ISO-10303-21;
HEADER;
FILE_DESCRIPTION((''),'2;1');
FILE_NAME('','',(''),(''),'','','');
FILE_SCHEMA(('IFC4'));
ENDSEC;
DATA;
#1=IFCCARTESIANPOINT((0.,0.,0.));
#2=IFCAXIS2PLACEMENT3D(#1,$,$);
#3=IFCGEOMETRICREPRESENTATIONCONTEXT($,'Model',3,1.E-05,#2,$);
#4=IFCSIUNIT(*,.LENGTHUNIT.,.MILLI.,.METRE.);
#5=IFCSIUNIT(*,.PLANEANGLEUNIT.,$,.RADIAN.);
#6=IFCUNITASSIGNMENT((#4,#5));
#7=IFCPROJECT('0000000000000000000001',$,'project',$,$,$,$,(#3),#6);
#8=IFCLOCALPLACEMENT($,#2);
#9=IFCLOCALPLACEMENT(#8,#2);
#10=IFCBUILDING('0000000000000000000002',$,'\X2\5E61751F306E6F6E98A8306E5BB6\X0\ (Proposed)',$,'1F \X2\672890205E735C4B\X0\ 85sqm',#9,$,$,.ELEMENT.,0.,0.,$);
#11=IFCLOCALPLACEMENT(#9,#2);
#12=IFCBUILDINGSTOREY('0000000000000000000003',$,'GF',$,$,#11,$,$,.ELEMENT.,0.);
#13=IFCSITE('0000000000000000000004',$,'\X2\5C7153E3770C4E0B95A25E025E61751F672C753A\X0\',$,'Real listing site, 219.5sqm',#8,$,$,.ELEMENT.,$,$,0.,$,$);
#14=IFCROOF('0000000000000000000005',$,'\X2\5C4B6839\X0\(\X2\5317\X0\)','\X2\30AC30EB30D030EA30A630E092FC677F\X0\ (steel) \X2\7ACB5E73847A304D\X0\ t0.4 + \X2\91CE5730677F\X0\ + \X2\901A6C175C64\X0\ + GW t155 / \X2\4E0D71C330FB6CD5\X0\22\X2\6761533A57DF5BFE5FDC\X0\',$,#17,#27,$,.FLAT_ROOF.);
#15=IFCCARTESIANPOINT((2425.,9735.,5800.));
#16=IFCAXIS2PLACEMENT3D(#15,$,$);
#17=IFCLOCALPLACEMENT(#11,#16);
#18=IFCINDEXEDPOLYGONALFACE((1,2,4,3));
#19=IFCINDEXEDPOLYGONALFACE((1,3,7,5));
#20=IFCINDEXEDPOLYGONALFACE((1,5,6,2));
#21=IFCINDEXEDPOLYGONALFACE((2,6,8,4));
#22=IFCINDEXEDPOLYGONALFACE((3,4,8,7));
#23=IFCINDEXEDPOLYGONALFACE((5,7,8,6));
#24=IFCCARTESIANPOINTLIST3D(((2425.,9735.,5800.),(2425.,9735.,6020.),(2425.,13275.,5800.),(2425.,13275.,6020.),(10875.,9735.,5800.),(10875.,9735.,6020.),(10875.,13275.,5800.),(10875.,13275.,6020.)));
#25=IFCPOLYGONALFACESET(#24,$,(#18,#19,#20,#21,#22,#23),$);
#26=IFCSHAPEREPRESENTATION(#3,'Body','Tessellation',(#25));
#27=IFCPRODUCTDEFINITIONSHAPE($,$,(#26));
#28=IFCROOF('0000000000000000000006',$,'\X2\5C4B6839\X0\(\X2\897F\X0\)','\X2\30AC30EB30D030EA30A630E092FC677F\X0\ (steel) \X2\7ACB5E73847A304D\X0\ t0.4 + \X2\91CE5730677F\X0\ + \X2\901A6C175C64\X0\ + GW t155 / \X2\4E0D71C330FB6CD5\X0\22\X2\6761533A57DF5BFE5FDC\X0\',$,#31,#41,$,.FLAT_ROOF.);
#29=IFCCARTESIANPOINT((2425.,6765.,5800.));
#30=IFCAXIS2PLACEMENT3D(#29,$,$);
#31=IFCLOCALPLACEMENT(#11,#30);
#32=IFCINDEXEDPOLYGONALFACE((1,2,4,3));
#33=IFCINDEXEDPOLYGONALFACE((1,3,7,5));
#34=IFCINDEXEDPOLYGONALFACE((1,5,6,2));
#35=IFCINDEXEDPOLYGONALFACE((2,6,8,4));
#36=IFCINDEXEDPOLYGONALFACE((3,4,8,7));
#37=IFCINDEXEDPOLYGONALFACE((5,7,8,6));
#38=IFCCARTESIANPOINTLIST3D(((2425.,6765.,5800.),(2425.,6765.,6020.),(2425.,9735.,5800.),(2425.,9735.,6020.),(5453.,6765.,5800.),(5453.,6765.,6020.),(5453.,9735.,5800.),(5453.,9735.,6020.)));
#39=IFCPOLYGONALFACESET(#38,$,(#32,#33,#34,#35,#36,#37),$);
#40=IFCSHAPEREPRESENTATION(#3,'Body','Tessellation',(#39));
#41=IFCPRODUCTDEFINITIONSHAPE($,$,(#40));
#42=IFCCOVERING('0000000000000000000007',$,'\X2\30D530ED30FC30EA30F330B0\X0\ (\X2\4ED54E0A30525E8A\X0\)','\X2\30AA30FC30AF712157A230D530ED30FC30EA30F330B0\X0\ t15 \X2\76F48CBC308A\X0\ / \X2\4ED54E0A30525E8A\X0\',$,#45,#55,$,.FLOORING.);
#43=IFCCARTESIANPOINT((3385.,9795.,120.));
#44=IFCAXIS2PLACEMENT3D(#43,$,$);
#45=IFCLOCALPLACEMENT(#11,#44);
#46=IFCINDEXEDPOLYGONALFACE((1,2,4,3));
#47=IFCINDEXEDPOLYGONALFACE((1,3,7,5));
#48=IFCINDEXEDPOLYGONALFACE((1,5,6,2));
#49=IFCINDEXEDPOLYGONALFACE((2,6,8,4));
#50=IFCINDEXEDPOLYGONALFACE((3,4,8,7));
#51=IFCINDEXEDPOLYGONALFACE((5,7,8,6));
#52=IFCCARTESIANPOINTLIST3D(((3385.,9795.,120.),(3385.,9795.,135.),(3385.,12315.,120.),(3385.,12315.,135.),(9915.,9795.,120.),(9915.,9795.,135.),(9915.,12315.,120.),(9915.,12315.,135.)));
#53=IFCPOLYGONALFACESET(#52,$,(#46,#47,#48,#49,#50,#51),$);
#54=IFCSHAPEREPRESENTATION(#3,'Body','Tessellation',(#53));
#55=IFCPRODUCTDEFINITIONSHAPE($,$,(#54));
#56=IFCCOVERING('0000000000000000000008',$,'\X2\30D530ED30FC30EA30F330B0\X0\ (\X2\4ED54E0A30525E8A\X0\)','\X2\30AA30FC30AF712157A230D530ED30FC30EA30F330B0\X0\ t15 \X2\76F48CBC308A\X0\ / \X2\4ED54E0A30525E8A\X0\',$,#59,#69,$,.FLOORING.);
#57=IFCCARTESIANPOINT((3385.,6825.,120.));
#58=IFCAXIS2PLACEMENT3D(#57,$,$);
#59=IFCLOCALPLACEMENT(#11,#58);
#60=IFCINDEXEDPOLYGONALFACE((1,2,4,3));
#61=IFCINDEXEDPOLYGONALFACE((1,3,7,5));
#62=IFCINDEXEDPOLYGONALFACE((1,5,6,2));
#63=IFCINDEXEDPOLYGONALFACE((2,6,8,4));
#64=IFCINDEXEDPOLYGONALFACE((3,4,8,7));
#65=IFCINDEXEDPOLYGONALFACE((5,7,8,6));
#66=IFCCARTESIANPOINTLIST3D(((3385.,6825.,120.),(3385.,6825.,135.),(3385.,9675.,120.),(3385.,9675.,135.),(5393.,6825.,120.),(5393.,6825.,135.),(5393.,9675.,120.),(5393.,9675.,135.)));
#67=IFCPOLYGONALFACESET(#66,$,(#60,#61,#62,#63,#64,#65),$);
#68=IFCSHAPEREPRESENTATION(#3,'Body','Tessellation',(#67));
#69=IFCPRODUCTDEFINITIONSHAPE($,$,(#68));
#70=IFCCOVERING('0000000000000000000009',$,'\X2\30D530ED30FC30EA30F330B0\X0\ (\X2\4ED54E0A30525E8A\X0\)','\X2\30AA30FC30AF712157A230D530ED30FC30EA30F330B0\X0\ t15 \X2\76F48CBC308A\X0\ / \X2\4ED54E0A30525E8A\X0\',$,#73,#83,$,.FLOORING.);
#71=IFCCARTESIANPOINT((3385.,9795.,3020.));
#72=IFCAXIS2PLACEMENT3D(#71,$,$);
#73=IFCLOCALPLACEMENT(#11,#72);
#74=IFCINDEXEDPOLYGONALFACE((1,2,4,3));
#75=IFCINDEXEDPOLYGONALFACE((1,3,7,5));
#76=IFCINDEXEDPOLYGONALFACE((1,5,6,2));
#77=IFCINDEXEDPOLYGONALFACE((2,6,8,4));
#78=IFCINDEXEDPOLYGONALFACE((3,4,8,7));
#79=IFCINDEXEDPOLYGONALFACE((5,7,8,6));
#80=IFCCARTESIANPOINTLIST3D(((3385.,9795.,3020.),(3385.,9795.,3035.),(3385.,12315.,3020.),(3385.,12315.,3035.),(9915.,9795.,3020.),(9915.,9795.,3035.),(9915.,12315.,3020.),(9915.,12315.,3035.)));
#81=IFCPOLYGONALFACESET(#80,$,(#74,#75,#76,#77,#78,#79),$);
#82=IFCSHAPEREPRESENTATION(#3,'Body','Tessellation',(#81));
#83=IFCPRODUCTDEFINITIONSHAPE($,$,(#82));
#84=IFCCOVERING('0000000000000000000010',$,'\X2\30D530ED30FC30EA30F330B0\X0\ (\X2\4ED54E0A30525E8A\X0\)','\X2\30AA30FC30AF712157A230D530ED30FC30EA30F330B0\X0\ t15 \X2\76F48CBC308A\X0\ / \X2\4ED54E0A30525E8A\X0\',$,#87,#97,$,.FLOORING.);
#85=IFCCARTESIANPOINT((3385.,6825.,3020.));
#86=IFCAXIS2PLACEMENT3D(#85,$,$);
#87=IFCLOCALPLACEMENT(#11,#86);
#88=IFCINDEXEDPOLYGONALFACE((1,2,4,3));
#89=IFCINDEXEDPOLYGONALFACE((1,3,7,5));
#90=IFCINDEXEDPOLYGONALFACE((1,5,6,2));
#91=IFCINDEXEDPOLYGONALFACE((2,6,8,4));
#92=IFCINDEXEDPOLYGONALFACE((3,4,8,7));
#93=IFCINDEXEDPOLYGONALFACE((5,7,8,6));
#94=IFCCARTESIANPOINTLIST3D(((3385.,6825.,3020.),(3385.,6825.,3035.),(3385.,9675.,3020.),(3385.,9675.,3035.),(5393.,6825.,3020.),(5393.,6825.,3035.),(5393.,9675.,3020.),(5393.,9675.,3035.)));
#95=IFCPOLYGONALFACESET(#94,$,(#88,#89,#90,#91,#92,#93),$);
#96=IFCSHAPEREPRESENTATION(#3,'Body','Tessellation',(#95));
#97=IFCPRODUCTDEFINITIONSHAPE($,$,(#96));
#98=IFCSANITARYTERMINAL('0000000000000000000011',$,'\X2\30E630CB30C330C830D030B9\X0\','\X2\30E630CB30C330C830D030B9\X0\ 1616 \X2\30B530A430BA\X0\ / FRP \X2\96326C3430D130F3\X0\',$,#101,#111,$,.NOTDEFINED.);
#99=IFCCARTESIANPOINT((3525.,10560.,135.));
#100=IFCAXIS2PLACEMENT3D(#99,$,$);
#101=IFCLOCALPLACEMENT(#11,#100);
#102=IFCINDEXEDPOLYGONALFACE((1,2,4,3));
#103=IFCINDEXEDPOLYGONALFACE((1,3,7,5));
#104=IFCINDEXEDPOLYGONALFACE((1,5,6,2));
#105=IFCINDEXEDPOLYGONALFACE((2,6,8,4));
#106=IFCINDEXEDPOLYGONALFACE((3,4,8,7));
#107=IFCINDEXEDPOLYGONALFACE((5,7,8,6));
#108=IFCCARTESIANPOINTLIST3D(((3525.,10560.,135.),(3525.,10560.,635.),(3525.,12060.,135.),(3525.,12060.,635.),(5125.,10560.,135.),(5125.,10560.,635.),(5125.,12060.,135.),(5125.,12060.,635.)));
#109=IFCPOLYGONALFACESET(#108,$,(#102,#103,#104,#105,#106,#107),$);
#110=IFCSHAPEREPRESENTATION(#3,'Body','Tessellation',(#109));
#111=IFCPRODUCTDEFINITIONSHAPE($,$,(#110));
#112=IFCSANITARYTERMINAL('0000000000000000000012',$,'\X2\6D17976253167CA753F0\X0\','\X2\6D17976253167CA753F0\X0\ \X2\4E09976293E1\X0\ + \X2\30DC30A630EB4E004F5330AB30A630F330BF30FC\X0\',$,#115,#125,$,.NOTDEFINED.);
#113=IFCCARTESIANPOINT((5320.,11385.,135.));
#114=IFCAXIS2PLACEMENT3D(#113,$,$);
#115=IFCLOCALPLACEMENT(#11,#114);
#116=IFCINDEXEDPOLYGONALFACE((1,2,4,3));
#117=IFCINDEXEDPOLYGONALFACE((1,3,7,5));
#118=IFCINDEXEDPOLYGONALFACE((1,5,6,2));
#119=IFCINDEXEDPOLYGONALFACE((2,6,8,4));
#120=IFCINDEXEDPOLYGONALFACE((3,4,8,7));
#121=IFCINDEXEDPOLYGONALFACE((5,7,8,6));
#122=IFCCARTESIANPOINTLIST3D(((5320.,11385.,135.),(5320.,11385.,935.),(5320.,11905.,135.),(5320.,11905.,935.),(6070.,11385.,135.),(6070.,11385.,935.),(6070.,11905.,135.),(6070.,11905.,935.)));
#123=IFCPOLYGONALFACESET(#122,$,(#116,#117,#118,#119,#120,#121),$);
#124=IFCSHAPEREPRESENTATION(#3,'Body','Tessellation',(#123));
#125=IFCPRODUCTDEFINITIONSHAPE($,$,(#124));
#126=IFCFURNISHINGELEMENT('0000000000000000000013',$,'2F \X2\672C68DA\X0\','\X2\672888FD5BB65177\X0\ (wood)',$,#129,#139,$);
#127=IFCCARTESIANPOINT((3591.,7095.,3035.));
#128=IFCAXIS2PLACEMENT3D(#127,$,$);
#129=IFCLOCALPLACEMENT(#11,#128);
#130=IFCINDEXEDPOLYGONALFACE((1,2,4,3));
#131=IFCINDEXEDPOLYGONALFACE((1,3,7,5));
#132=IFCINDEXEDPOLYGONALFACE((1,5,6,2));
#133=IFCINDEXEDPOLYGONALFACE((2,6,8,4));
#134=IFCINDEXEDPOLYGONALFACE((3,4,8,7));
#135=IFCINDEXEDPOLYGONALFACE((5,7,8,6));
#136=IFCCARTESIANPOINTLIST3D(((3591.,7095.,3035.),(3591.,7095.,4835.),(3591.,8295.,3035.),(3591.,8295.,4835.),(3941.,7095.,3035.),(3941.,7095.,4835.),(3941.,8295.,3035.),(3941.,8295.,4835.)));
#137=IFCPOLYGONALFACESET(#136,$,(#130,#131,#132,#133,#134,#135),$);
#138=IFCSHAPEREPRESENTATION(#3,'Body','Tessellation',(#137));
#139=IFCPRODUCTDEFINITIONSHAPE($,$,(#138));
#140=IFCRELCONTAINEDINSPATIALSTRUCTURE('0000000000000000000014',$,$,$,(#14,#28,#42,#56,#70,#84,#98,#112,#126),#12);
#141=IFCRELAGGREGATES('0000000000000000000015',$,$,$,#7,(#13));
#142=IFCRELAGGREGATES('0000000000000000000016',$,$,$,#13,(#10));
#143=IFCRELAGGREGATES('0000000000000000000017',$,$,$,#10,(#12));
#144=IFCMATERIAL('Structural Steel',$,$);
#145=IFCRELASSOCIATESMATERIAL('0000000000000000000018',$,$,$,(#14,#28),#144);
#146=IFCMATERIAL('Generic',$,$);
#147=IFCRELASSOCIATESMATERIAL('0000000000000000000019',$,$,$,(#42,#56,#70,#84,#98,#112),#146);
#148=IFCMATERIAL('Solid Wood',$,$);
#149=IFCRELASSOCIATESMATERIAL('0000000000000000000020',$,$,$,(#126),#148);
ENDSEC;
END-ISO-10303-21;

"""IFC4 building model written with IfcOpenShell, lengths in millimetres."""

from ifc_helpers import new_model, si_unit, frame, frame_2d, origin, place, context, project, spatial, rectangle, extrude, material, element, save


model = new_model("IFC4")

# Units and contexts
model_context = context("Model", 3, precision=1e-05, world=origin())
ifc_project = project(units=[si_unit("LENGTHUNIT", "METRE", prefix="MILLI"), si_unit("PLANEANGLEUNIT", "RADIAN")], contexts=[model_context])

# Site, building, storey
site_placement = place(None, origin())
site = spatial("IfcSite", under=ifc_project, at=site_placement, Name="山口県下関市幡生本町", ObjectType="Real listing site, 219.5sqm", CompositionType="ELEMENT", RefElevation=0.0)
building_placement = place(site_placement, origin())
building = spatial("IfcBuilding", under=site, at=building_placement, Name="幡生の潮風の家 (Proposed)", ObjectType="1F 木造平屋 85sqm", CompositionType="ELEMENT", ElevationOfRefHeight=0.0, ElevationOfTerrain=0.0)
storey_placement = place(building_placement, origin())
storey = spatial("IfcBuildingStorey", under=building, at=storey_placement, Name="GF", CompositionType="ELEMENT", Elevation=0.0)

# Shared definitions
ifc_material_1 = material(Name="Solid Wood")

# Roofs
ifc_material_2 = material(Name="Structural Steel")
for number, where, name in (
    (1, (2425.0, 9735.0, 5800.0), "屋根(北)"),
):
    element("IfcRoof", number, at=place(storey_placement, frame(where)), inside=storey, material=ifc_material_2, Name=name, Description="ガルバリウム鋼板 (steel) 立平葺き t0.4 + 野地板 + 通気層 + GW t155 / 不燃・法22条区域対応", PredefinedType="FLAT_ROOF", context=model_context, shape_type="SweptSolid", body=[
        extrude(rectangle(XDim=8450.0, YDim=3540.0, at=frame_2d((4225.0, 1770.0))), frame((2425.0, 9735.0, 5800.0)), (0.0, 0.0, 1.0), 220.0),
    ])
roof_placement = place(storey_placement, frame((2425.0, 6765.0, 5800.0)))
element("IfcRoof", 2, at=roof_placement, inside=storey, material=ifc_material_2, Name="屋根(西)", Description="ガルバリウム鋼板 (steel) 立平葺き t0.4 + 野地板 + 通気層 + GW t155 / 不燃・法22条区域対応", PredefinedType="FLAT_ROOF", context=model_context, shape_type="SweptSolid", body=[
    extrude(rectangle(XDim=3028.0, YDim=2970.0, at=frame_2d((1514.0, 1485.0))), frame((2425.0, 6765.0, 5800.0)), (0.0, 0.0, 1.0), 220.0),
])

# Coverings
ifc_material_3 = material(Name="Generic")
covering_1_placement = place(storey_placement, frame((3385.0, 9795.0, 120.0)))
element("IfcCovering", 3, at=covering_1_placement, inside=storey, material=ifc_material_3, Name="フローリング (仕上げ床)", Description="オーク無垢フローリング t15 直貼り / 仕上げ床", PredefinedType="FLOORING", context=model_context, shape_type="SweptSolid", body=[
    extrude(rectangle(XDim=6530.0, YDim=2520.0, at=frame_2d((3265.0, 1260.0))), frame((3385.0, 9795.0, 120.0)), (0.0, 0.0, 1.0), 15.0),
])
covering_2_placement = place(storey_placement, frame((3385.0, 6825.0, 120.0)))
element("IfcCovering", 4, at=covering_2_placement, inside=storey, material=ifc_material_3, Name="フローリング (仕上げ床)", Description="オーク無垢フローリング t15 直貼り / 仕上げ床", PredefinedType="FLOORING", context=model_context, shape_type="SweptSolid", body=[
    extrude(rectangle(XDim=2008.0, YDim=2850.0, at=frame_2d((1004.0, 1425.0))), frame((3385.0, 6825.0, 120.0)), (0.0, 0.0, 1.0), 15.0),
])
covering_3_placement = place(storey_placement, frame((3385.0, 9795.0, 3020.0)))
element("IfcCovering", 5, at=covering_3_placement, inside=storey, material=ifc_material_3, Name="フローリング (仕上げ床)", Description="オーク無垢フローリング t15 直貼り / 仕上げ床", PredefinedType="FLOORING", context=model_context, shape_type="SweptSolid", body=[
    extrude(rectangle(XDim=6530.0, YDim=2520.0, at=frame_2d((3265.0, 1260.0))), frame((3385.0, 9795.0, 3020.0)), (0.0, 0.0, 1.0), 15.0),
])
covering_4_placement = place(storey_placement, frame((3385.0, 6825.0, 3020.0)))
element("IfcCovering", 6, at=covering_4_placement, inside=storey, material=ifc_material_3, Name="フローリング (仕上げ床)", Description="オーク無垢フローリング t15 直貼り / 仕上げ床", PredefinedType="FLOORING", context=model_context, shape_type="SweptSolid", body=[
    extrude(rectangle(XDim=2008.0, YDim=2850.0, at=frame_2d((1004.0, 1425.0))), frame((3385.0, 6825.0, 3020.0)), (0.0, 0.0, 1.0), 15.0),
])

# Sanitary terminals
sanitary_terminal_1_placement = place(storey_placement, frame((3525.0, 10560.0, 135.0)))
element("IfcSanitaryTerminal", 7, at=sanitary_terminal_1_placement, inside=storey, material=ifc_material_3, Name="ユニットバス", Description="ユニットバス 1616 サイズ / FRP 防水パン", PredefinedType="NOTDEFINED", context=model_context, shape_type="SweptSolid", body=[
    extrude(rectangle(XDim=1600.0, YDim=1500.0, at=frame_2d((800.0, 750.0))), frame((3525.0, 10560.0, 135.0)), (0.0, 0.0, 1.0), 500.0),
])
sanitary_terminal_2_placement = place(storey_placement, frame((5320.0, 11385.0, 135.0)))
element("IfcSanitaryTerminal", 8, at=sanitary_terminal_2_placement, inside=storey, material=ifc_material_3, Name="洗面化粧台", Description="洗面化粧台 三面鏡 + ボウル一体カウンター", PredefinedType="NOTDEFINED", context=model_context, shape_type="SweptSolid", body=[
    extrude(rectangle(XDim=750.0, YDim=520.0, at=frame_2d((375.0, 260.0))), frame((5320.0, 11385.0, 135.0)), (0.0, 0.0, 1.0), 800.0),
])

# Furnishing element
furnishing_placement = place(storey_placement, frame((3591.0, 7095.0, 3035.0)))
element("IfcFurnishingElement", 9, at=furnishing_placement, inside=storey, material=ifc_material_1, Name="2F 本棚", Description="木製家具 (wood)", context=model_context, shape_type="SweptSolid", body=[
    extrude(rectangle(XDim=350.0, YDim=1200.0, at=frame_2d((175.0, 600.0))), frame((3591.0, 7095.0, 3035.0)), (0.0, 0.0, 1.0), 1800.0),
])

save(model, "model.ifc")
